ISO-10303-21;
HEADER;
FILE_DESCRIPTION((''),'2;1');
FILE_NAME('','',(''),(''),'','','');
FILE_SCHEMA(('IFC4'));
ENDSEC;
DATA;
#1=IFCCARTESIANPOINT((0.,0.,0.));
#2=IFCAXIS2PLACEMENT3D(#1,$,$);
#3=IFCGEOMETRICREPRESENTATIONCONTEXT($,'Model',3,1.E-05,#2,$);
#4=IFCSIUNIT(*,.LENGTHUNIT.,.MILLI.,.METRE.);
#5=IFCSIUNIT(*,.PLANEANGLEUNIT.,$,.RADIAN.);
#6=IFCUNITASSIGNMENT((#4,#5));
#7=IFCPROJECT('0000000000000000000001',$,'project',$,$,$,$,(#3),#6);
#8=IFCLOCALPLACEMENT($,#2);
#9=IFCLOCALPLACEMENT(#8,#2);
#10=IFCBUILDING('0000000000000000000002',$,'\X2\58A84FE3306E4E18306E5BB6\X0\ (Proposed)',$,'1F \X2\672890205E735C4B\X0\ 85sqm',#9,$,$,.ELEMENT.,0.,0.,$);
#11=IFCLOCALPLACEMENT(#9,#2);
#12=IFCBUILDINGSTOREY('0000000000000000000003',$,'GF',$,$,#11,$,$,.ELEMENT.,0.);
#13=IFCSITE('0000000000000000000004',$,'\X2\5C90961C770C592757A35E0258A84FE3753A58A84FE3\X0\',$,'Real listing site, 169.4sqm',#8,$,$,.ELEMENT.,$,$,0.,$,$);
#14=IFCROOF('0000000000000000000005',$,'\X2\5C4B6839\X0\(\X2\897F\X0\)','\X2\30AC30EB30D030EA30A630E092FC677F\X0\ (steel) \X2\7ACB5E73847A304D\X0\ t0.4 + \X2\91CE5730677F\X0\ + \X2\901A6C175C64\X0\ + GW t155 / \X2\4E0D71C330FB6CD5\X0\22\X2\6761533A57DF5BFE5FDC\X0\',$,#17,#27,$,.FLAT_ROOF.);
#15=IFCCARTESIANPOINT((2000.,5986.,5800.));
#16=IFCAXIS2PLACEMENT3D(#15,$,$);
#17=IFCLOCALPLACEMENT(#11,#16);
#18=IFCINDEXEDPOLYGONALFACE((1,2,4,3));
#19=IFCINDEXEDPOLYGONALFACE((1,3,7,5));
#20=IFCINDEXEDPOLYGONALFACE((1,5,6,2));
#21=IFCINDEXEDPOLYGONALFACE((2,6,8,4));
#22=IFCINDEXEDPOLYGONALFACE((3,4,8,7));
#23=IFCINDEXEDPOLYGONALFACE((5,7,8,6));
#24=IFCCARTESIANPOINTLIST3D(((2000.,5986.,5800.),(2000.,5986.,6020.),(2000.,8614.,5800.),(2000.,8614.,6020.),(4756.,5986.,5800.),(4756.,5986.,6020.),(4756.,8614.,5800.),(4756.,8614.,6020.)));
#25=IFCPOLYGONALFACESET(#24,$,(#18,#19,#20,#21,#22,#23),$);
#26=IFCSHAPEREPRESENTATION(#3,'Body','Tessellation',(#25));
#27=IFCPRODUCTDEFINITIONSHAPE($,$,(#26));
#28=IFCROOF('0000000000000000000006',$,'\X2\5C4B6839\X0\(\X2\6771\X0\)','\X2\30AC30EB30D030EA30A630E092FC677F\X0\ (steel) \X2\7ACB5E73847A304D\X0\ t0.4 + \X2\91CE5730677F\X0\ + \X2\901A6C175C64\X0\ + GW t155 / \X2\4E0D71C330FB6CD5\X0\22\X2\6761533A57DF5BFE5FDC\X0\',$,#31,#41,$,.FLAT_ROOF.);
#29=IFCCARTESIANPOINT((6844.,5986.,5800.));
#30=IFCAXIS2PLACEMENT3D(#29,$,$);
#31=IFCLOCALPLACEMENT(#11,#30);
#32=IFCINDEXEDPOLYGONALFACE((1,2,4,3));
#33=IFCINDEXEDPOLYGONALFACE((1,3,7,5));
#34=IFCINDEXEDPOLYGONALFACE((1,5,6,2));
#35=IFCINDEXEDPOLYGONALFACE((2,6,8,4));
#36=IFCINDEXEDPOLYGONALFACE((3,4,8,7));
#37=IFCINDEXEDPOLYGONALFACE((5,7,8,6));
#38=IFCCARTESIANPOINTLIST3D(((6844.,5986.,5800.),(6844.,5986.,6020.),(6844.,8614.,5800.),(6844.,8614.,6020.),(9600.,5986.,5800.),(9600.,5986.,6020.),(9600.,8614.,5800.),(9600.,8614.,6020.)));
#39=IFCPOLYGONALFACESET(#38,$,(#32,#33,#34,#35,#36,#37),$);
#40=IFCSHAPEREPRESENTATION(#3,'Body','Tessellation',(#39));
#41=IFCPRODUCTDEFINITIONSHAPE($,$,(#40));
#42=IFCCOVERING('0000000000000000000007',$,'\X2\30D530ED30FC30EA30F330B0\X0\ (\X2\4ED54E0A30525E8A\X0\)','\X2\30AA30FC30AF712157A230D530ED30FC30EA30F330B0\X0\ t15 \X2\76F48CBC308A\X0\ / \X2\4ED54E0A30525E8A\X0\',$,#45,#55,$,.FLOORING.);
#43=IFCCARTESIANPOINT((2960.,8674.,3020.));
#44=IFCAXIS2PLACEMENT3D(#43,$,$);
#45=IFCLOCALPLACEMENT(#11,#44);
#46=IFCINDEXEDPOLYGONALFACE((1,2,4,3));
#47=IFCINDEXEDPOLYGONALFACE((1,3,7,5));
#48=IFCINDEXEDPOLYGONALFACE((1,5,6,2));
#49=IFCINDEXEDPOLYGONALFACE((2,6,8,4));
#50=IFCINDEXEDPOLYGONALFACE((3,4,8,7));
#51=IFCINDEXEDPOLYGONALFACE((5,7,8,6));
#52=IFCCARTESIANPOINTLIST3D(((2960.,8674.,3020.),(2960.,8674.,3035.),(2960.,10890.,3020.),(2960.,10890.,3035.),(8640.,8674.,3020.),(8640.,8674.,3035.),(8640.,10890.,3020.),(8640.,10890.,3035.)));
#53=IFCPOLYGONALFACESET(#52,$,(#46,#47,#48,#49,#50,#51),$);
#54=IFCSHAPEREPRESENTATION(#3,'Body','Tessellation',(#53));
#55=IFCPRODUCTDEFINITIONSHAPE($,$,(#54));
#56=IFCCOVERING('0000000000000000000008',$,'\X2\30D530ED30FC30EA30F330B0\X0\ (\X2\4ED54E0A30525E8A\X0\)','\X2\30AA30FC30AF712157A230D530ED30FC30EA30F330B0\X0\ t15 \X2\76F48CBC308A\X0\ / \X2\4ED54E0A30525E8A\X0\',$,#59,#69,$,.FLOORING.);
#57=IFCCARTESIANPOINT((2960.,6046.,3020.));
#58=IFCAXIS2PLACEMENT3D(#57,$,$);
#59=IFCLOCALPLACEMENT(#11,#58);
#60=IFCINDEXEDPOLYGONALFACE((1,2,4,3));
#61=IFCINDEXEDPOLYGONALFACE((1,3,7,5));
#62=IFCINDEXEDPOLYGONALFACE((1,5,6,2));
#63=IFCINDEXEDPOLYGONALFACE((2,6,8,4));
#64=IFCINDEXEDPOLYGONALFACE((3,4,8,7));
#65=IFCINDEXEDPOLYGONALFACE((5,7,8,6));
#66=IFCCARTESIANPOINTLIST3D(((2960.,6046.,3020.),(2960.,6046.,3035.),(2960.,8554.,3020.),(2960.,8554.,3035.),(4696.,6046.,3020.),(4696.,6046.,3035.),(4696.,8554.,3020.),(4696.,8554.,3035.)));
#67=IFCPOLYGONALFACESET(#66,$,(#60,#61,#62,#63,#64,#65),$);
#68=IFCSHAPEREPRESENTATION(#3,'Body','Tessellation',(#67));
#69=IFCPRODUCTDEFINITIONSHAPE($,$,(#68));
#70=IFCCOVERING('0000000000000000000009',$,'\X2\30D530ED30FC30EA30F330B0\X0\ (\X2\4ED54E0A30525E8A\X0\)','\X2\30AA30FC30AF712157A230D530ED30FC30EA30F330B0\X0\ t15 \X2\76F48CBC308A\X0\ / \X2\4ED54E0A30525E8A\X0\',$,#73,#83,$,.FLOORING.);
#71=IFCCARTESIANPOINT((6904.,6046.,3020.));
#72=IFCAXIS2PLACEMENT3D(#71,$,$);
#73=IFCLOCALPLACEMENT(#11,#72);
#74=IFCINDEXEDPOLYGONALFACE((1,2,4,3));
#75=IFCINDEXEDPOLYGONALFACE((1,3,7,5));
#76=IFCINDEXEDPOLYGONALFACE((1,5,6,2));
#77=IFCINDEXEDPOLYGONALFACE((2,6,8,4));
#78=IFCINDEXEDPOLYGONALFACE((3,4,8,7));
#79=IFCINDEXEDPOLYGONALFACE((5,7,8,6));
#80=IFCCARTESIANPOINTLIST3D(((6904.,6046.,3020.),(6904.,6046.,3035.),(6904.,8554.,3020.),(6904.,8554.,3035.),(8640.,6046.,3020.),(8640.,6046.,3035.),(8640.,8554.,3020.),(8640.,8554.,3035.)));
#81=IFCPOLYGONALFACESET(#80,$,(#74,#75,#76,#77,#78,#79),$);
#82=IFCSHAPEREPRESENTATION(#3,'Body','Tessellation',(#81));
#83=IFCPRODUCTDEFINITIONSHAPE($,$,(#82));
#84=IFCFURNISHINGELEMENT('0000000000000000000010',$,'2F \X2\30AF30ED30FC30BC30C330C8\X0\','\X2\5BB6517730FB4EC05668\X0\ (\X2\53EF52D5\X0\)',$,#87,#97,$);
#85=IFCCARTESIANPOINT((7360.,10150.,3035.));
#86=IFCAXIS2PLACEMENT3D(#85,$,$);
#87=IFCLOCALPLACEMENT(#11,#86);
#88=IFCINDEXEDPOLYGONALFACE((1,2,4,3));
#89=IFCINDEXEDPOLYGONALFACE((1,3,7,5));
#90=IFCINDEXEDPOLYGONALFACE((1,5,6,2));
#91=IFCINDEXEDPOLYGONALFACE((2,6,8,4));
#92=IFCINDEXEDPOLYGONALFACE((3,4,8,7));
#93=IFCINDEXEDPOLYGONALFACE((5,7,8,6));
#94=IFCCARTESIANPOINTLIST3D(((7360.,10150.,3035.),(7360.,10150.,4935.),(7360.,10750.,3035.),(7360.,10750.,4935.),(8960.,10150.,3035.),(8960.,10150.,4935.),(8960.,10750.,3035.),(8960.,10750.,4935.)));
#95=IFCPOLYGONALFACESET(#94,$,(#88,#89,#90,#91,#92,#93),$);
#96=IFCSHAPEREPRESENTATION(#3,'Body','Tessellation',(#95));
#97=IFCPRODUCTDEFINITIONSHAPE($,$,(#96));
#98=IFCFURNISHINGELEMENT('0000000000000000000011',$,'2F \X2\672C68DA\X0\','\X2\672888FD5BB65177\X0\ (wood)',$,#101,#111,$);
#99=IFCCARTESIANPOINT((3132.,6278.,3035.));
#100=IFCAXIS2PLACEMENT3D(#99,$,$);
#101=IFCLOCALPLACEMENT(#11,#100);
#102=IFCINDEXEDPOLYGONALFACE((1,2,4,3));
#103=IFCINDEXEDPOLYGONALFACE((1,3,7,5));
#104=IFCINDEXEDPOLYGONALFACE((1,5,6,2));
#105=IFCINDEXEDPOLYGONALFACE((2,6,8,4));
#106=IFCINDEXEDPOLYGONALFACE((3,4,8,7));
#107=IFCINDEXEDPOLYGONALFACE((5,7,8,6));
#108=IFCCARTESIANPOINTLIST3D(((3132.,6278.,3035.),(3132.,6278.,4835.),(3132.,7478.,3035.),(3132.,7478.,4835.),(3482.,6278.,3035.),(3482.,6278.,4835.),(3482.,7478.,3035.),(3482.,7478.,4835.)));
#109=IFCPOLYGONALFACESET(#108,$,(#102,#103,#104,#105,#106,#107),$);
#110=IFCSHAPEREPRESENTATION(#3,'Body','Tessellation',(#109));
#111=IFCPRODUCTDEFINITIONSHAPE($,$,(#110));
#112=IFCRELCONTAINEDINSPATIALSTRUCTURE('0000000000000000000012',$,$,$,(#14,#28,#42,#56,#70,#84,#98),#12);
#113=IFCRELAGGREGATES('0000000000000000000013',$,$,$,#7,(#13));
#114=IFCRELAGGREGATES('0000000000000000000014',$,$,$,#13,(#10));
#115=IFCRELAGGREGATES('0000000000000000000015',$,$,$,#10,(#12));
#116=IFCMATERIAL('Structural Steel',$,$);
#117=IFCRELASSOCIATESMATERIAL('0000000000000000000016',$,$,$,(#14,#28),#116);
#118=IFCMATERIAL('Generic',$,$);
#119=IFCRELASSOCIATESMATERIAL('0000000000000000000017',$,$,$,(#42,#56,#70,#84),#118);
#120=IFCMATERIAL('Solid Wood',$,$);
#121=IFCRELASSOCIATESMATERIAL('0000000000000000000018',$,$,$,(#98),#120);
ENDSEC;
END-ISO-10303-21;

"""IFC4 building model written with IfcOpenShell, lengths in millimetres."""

from ifc_helpers import new_model, si_unit, frame, frame_2d, origin, place, context, project, spatial, rectangle, extrude, material, element, save


model = new_model("IFC4")

# Units and contexts
model_context = context("Model", 3, precision=1e-05, world=origin())
ifc_project = project(units=[si_unit("LENGTHUNIT", "METRE", prefix="MILLI"), si_unit("PLANEANGLEUNIT", "RADIAN")], contexts=[model_context])

# Site, building, storey
site_placement = place(None, origin())
site = spatial("IfcSite", under=ifc_project, at=site_placement, Name="岐阜県大垣市墨俣町墨俣", ObjectType="Real listing site, 169.4sqm", CompositionType="ELEMENT", RefElevation=0.0)
building_placement = place(site_placement, origin())
building = spatial("IfcBuilding", under=site, at=building_placement, Name="墨俣の丘の家 (Proposed)", ObjectType="1F 木造平屋 85sqm", CompositionType="ELEMENT", ElevationOfRefHeight=0.0, ElevationOfTerrain=0.0)
storey_placement = place(building_placement, origin())
storey = spatial("IfcBuildingStorey", under=building, at=storey_placement, Name="GF", CompositionType="ELEMENT", Elevation=0.0)

# Shared definitions
ifc_material_1 = material(Name="Solid Wood")

# Shared definitions
ifc_material_2 = material(Name="Generic")

# Roofs
ifc_material_3 = material(Name="Structural Steel")
roof_1_placement = place(storey_placement, frame((2000.0, 5986.0, 5800.0)))
element("IfcRoof", 1, at=roof_1_placement, inside=storey, material=ifc_material_3, Name="屋根(西)", Description="ガルバリウム鋼板 (steel) 立平葺き t0.4 + 野地板 + 通気層 + GW t155 / 不燃・法22条区域対応", PredefinedType="FLAT_ROOF", context=model_context, shape_type="SweptSolid", body=[
    extrude(rectangle(XDim=2756.0, YDim=2628.0, at=frame_2d((1378.0, 1314.0))), frame((2000.0, 5986.0, 5800.0)), (0.0, 0.0, 1.0), 220.0),
])
roof_2_placement = place(storey_placement, frame((6844.0, 5986.0, 5800.0)))
element("IfcRoof", 2, at=roof_2_placement, inside=storey, material=ifc_material_3, Name="屋根(東)", Description="ガルバリウム鋼板 (steel) 立平葺き t0.4 + 野地板 + 通気層 + GW t155 / 不燃・法22条区域対応", PredefinedType="FLAT_ROOF", context=model_context, shape_type="SweptSolid", body=[
    extrude(rectangle(XDim=2756.0, YDim=2628.0, at=frame_2d((1378.0, 1314.0))), frame((6844.0, 5986.0, 5800.0)), (0.0, 0.0, 1.0), 220.0),
])

# Coverings
covering_1_placement = place(storey_placement, frame((2960.0, 8674.0, 3020.0)))
element("IfcCovering", 3, at=covering_1_placement, inside=storey, material=ifc_material_2, Name="フローリング (仕上げ床)", Description="オーク無垢フローリング t15 直貼り / 仕上げ床", PredefinedType="FLOORING", context=model_context, shape_type="SweptSolid", body=[
    extrude(rectangle(XDim=5680.0, YDim=2216.0, at=frame_2d((2840.0, 1108.0))), frame((2960.0, 8674.0, 3020.0)), (0.0, 0.0, 1.0), 15.0),
])
covering_2_placement = place(storey_placement, frame((2960.0, 6046.0, 3020.0)))
element("IfcCovering", 4, at=covering_2_placement, inside=storey, material=ifc_material_2, Name="フローリング (仕上げ床)", Description="オーク無垢フローリング t15 直貼り / 仕上げ床", PredefinedType="FLOORING", context=model_context, shape_type="SweptSolid", body=[
    extrude(rectangle(XDim=1736.0, YDim=2508.0, at=frame_2d((868.0, 1254.0))), frame((2960.0, 6046.0, 3020.0)), (0.0, 0.0, 1.0), 15.0),
])
covering_3_placement = place(storey_placement, frame((6904.0, 6046.0, 3020.0)))
element("IfcCovering", 5, at=covering_3_placement, inside=storey, material=ifc_material_2, Name="フローリング (仕上げ床)", Description="オーク無垢フローリング t15 直貼り / 仕上げ床", PredefinedType="FLOORING", context=model_context, shape_type="SweptSolid", body=[
    extrude(rectangle(XDim=1736.0, YDim=2508.0, at=frame_2d((868.0, 1254.0))), frame((6904.0, 6046.0, 3020.0)), (0.0, 0.0, 1.0), 15.0),
])

# Furnishing elements
furnishing_1_placement = place(storey_placement, frame((7360.0, 10150.0, 3035.0)))
element("IfcFurnishingElement", 6, at=furnishing_1_placement, inside=storey, material=ifc_material_2, Name="2F クローゼット", Description="家具・什器 (可動)", context=model_context, shape_type="SweptSolid", body=[
    extrude(rectangle(XDim=1600.0, YDim=600.0, at=frame_2d((800.0, 300.0))), frame((7360.0, 10150.0, 3035.0)), (0.0, 0.0, 1.0), 1900.0),
])
furnishing_2_placement = place(storey_placement, frame((3132.0, 6278.0, 3035.0)))
element("IfcFurnishingElement", 7, at=furnishing_2_placement, inside=storey, material=ifc_material_1, Name="2F 本棚", Description="木製家具 (wood)", context=model_context, shape_type="SweptSolid", body=[
    extrude(rectangle(XDim=350.0, YDim=1200.0, at=frame_2d((175.0, 600.0))), frame((3132.0, 6278.0, 3035.0)), (0.0, 0.0, 1.0), 1800.0),
])

save(model, "model.ifc")
